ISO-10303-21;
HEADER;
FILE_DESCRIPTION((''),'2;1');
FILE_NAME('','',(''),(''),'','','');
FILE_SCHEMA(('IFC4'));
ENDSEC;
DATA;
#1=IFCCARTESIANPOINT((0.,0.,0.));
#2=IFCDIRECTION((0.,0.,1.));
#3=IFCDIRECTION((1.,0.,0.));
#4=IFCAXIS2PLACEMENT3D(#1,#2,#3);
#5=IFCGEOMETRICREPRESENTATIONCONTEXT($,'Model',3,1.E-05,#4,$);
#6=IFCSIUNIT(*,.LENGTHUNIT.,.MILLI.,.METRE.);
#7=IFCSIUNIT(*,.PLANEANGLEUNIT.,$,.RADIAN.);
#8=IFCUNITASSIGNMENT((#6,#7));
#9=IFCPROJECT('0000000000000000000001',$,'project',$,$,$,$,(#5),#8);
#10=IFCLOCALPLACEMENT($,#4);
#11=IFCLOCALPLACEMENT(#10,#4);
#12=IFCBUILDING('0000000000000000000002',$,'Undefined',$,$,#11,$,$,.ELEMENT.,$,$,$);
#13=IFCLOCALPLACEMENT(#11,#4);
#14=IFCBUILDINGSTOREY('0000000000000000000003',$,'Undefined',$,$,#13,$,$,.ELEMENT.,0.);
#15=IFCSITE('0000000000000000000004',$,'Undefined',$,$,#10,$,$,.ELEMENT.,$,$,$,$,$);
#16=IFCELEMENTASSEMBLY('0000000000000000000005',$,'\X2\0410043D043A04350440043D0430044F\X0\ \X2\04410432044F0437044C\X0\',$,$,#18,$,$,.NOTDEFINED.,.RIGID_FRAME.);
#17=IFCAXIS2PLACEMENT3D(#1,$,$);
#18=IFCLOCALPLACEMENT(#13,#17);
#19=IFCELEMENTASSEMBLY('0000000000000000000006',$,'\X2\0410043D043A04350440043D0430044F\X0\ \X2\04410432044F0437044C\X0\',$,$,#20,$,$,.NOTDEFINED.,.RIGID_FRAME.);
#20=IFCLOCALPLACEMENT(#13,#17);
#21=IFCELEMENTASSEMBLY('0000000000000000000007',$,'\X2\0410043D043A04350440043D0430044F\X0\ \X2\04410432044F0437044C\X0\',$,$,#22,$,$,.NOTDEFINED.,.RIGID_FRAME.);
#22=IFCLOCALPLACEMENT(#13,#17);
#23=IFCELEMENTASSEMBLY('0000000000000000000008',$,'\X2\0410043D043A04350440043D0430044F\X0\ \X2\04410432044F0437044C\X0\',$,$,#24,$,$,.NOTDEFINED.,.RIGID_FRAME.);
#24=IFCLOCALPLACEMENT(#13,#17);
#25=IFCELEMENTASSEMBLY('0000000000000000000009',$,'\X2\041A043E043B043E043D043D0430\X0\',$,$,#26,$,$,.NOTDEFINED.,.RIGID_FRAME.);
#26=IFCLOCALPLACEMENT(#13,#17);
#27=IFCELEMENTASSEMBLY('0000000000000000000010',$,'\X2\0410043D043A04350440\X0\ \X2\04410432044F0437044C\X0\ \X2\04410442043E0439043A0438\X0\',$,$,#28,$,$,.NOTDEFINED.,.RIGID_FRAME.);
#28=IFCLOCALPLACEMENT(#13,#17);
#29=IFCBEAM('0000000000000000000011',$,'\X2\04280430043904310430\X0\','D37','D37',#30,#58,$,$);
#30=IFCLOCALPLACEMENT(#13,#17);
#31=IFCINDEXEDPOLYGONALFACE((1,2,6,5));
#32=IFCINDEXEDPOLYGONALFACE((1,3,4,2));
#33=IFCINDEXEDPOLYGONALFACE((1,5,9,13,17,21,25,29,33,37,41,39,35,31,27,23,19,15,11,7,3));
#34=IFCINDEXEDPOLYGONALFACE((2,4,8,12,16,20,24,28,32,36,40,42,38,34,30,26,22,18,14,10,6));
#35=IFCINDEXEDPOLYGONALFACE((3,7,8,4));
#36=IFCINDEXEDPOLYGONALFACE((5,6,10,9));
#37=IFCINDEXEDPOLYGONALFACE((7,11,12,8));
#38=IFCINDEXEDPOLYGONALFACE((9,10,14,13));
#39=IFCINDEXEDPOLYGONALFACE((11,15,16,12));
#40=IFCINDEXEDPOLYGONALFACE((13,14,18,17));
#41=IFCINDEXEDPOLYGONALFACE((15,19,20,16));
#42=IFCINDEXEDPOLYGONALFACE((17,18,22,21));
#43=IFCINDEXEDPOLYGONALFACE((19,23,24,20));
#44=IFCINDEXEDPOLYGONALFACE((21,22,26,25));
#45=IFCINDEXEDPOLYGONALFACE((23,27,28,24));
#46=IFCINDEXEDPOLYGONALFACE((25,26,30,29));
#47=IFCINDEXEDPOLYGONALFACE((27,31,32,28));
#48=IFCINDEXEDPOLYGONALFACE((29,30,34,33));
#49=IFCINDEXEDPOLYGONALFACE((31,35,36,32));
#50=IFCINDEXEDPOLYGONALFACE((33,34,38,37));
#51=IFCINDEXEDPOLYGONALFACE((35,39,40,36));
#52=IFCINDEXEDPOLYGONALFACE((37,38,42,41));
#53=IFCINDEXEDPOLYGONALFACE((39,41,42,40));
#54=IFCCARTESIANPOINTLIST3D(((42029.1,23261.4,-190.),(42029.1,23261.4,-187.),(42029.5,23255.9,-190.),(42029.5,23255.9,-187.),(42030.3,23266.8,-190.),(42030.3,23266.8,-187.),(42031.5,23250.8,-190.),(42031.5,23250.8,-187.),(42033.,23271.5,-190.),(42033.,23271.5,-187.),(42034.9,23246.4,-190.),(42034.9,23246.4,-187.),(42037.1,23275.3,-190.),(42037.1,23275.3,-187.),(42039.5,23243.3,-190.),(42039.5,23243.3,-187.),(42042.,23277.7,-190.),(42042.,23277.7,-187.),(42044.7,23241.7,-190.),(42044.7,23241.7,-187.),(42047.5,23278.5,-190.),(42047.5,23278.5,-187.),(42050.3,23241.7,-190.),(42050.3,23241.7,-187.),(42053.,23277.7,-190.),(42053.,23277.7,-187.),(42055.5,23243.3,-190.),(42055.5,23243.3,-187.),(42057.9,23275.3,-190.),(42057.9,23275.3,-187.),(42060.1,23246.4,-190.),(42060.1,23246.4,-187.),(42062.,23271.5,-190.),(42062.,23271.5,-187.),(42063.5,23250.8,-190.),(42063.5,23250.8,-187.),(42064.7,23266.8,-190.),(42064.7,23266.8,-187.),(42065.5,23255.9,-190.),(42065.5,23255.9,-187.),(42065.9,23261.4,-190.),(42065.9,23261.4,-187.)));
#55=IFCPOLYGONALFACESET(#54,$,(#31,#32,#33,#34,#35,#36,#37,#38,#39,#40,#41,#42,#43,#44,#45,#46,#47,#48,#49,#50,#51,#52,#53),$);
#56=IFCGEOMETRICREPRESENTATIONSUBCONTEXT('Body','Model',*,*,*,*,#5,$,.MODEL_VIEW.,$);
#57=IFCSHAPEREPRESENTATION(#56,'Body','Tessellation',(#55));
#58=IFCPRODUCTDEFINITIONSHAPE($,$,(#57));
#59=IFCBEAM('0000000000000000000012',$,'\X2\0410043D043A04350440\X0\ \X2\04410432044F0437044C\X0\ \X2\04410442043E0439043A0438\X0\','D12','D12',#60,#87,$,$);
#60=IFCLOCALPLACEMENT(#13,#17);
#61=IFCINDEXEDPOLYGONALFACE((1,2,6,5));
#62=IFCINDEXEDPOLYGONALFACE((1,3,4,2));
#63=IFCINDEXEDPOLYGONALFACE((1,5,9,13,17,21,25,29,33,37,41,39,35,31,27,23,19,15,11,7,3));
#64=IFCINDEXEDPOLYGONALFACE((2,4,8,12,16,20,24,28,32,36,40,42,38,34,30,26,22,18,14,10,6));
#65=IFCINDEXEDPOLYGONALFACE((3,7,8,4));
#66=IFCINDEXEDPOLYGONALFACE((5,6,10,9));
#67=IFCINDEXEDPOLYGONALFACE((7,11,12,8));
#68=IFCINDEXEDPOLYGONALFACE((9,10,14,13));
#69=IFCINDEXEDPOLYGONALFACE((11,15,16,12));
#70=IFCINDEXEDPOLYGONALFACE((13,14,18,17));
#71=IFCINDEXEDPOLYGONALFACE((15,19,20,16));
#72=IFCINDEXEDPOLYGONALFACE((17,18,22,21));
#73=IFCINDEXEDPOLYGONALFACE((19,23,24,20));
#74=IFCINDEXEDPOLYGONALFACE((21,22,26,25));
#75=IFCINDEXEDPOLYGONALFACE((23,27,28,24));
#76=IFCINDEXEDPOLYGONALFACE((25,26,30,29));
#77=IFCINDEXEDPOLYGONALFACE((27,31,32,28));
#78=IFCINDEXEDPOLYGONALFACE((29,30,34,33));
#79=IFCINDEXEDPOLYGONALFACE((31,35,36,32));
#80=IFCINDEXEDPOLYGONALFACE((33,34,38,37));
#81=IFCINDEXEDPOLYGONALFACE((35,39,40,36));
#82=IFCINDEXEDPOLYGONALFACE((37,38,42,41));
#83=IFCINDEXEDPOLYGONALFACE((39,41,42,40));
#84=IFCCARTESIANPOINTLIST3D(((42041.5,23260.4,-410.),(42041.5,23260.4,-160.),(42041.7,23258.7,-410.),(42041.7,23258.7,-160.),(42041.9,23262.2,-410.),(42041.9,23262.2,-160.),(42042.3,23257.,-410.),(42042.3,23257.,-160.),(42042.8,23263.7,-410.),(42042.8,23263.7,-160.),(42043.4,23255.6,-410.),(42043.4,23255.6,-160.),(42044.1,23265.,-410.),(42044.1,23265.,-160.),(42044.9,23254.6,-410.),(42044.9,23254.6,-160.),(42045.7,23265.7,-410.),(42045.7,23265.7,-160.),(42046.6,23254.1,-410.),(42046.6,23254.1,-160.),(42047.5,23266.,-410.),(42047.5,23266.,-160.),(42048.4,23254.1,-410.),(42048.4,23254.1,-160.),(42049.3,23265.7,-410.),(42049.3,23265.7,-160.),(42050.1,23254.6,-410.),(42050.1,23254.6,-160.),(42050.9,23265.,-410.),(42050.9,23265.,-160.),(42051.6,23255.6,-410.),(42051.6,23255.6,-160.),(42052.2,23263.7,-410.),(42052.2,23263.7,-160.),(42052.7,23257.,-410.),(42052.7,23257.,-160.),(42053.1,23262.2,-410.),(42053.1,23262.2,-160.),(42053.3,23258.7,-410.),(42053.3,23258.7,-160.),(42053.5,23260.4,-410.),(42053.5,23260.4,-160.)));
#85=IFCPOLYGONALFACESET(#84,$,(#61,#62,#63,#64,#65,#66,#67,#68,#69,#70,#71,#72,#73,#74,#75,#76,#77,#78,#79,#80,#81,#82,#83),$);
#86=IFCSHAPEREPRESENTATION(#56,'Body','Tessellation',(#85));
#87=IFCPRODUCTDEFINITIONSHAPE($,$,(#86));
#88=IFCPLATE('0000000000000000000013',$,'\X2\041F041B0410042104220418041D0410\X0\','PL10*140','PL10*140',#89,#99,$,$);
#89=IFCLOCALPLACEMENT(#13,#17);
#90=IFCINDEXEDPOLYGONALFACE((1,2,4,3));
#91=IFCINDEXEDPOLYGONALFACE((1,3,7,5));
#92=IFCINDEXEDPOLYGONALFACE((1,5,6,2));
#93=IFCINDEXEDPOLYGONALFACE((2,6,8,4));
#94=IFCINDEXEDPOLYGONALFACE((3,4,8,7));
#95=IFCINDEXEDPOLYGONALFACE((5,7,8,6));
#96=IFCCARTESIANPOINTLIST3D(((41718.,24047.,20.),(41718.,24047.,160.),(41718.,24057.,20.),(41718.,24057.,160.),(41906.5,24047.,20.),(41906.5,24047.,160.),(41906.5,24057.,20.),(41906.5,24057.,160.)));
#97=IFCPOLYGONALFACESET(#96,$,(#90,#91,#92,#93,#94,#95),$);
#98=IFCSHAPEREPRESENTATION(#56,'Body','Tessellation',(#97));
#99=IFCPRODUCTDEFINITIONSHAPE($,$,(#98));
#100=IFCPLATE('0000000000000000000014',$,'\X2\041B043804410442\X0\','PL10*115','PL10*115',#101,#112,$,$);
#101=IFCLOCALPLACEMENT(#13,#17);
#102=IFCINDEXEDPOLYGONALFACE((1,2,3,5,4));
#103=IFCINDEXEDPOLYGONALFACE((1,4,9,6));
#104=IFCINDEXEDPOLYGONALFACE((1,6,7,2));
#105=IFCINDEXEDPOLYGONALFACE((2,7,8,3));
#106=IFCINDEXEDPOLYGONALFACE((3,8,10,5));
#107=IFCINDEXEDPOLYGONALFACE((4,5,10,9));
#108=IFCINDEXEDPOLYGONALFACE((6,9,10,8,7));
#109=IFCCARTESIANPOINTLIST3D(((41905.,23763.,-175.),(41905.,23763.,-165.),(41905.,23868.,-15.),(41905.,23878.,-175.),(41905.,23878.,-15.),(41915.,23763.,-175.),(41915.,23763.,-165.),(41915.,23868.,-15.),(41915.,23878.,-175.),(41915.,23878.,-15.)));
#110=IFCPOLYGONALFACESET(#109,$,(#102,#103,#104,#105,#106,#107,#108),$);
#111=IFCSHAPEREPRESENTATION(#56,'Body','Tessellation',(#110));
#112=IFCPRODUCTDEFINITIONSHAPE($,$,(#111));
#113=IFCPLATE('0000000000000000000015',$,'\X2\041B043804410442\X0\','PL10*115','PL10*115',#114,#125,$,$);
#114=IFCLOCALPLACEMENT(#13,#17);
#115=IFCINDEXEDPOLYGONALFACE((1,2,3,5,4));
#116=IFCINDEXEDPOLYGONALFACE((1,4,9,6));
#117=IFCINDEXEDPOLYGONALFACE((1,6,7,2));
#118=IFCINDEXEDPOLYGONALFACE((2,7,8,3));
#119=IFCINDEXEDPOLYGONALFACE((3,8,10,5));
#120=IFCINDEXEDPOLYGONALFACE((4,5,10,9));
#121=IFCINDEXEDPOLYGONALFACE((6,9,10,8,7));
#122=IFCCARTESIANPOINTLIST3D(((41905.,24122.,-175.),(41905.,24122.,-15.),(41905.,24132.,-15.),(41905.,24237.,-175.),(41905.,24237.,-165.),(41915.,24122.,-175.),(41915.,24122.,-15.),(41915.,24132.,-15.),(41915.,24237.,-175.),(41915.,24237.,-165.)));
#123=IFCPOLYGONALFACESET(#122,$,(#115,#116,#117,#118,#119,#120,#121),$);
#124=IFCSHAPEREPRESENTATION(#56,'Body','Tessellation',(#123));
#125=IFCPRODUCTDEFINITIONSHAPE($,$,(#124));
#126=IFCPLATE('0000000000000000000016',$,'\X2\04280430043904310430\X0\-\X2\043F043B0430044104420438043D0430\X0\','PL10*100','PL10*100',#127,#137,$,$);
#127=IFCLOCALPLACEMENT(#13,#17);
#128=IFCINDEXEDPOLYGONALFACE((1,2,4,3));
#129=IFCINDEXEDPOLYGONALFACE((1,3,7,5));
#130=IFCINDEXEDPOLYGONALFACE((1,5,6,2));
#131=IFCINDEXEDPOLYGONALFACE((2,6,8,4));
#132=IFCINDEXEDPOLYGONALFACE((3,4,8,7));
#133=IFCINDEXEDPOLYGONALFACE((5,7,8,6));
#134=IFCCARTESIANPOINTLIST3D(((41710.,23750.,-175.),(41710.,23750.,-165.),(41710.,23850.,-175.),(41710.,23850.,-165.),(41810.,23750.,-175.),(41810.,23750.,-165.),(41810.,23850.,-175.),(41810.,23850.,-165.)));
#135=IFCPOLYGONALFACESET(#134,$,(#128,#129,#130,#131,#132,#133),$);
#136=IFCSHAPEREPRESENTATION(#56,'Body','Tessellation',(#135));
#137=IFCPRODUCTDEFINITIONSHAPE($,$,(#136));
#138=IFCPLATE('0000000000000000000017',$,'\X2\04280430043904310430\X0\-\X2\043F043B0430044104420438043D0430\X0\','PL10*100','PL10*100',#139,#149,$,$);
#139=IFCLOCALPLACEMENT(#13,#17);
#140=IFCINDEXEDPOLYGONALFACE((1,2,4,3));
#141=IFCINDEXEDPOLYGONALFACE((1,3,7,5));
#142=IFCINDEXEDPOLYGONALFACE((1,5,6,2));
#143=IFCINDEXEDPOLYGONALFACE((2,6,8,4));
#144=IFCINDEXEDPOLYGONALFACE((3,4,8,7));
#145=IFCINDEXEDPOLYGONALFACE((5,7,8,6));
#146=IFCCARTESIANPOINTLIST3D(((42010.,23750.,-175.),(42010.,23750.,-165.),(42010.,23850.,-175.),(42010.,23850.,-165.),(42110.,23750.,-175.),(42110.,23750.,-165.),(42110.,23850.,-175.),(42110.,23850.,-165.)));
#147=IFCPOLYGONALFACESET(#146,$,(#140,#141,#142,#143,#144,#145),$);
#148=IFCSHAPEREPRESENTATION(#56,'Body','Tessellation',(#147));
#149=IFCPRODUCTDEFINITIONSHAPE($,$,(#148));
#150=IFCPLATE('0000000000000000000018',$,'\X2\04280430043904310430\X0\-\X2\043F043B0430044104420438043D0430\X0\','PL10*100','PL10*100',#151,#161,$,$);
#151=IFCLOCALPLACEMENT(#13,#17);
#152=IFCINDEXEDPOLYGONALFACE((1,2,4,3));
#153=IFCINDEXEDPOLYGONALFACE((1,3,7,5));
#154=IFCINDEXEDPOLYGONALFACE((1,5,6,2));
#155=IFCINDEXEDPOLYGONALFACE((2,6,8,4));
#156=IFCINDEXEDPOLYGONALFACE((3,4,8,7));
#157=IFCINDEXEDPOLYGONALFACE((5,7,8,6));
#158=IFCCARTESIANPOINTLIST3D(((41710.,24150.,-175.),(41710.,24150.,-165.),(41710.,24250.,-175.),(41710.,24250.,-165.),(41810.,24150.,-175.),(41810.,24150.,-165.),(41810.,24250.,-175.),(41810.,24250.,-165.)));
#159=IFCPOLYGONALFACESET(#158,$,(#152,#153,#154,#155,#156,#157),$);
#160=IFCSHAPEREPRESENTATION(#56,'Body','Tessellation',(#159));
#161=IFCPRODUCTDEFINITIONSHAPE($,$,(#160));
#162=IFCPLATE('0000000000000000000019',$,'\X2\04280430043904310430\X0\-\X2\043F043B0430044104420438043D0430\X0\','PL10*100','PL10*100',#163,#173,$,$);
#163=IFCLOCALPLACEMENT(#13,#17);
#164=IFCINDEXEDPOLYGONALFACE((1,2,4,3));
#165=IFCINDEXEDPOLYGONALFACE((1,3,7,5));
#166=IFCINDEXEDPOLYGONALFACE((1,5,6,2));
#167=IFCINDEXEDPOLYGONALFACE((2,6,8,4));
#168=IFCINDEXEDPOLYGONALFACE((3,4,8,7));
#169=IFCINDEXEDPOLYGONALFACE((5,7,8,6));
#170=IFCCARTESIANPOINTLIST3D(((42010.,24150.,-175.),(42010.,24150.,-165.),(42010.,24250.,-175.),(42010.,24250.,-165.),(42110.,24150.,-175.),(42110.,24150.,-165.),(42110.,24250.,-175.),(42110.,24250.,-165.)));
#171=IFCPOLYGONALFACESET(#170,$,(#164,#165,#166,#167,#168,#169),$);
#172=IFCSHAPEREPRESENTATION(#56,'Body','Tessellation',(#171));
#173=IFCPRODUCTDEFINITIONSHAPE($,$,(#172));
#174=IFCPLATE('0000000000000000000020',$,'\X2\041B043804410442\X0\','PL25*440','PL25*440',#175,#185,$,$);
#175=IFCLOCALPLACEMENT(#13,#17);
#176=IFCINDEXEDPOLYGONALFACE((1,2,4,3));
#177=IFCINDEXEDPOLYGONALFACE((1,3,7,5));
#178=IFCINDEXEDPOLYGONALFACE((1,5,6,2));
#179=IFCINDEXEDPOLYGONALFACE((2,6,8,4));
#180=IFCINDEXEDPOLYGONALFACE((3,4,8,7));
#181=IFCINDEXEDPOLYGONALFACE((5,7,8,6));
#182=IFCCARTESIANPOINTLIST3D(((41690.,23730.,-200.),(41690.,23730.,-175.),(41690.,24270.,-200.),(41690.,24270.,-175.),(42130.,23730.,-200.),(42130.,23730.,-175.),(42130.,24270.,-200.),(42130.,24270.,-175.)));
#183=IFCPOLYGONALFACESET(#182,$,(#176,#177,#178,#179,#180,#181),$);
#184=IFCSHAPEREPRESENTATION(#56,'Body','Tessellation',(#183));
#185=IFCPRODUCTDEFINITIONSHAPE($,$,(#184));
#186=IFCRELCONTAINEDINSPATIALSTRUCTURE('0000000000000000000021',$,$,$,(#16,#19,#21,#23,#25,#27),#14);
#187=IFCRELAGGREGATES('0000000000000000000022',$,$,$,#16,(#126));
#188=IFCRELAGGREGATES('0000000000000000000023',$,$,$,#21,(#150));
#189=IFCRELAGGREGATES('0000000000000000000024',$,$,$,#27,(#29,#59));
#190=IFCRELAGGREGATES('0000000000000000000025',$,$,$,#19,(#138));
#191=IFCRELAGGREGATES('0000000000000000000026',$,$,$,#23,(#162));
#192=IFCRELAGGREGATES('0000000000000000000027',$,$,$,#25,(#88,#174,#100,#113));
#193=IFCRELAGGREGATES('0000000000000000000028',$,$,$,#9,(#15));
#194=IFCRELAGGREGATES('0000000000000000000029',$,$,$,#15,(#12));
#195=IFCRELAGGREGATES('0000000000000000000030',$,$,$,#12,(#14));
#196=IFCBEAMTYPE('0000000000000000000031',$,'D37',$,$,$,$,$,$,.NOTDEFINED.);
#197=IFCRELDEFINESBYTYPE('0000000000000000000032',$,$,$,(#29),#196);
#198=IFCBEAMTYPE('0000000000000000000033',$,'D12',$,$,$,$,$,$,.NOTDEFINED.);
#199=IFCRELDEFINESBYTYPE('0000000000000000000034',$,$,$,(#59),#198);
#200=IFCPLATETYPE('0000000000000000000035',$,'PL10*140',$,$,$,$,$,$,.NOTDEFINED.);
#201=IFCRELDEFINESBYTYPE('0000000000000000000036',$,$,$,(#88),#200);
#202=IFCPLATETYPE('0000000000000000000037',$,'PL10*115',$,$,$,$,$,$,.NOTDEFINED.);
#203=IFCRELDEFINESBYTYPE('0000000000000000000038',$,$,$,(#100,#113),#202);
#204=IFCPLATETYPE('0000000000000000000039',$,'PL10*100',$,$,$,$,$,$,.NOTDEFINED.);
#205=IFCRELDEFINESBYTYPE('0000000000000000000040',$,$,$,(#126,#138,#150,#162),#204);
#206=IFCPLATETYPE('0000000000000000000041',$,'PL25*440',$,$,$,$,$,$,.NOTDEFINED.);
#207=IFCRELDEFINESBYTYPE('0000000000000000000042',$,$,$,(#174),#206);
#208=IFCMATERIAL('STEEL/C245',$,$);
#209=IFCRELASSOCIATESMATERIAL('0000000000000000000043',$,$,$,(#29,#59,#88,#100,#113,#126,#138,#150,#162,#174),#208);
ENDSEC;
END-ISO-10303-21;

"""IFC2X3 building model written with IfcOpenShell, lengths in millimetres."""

from ifc_helpers import new_model, si_unit, frame, origin_with_axes, origin_2d_with_axis, place, context, subcontext, project, spatial, polyline, circle, outline, extrude, material, type_object, element, aggregate, save


model = new_model("IFC2X3")

# Units and contexts
model_context = context("Model", 3, precision=1e-05, world=origin_with_axes())
body_context = subcontext(model_context, "Body", "Model", "MODEL_VIEW")
ifc_project = project(units=[si_unit("LENGTHUNIT", "METRE", prefix="MILLI"), si_unit("PLANEANGLEUNIT", "RADIAN")], contexts=[model_context])

# Site, building, storey
site_placement = place(None, origin_with_axes())
site = spatial("IfcSite", under=ifc_project, at=site_placement, Name="Undefined", CompositionType="ELEMENT")
building_placement = place(site_placement, origin_with_axes())
building = spatial("IfcBuilding", under=site, at=building_placement, Name="Undefined", CompositionType="ELEMENT")
storey_placement = place(building_placement, origin_with_axes())
storey = spatial("IfcBuildingStorey", under=building, at=storey_placement, Name="Undefined", CompositionType="ELEMENT", Elevation=0.0)

# Element assembly
ifc_material_1 = material(Name="STEEL/C245")
assembly_1_placement = place(storey_placement, origin_with_axes())
assembly_1 = element("IfcElementAssembly", 1, at=assembly_1_placement, inside=storey, Name="Анкерная связь", AssemblyPlace="NOTDEFINED", PredefinedType="RIGID_FRAME")

# Element assembly
assembly_2_placement = place(storey_placement, origin_with_axes())
assembly_2 = element("IfcElementAssembly", 2, at=assembly_2_placement, inside=storey, Name="Анкерная связь", AssemblyPlace="NOTDEFINED", PredefinedType="RIGID_FRAME")

# Element assembly
assembly_3_placement = place(storey_placement, origin_with_axes())
assembly_3 = element("IfcElementAssembly", 3, at=assembly_3_placement, inside=storey, Name="Анкерная связь", AssemblyPlace="NOTDEFINED", PredefinedType="RIGID_FRAME")

# Element assembly
assembly_4_placement = place(storey_placement, origin_with_axes())
assembly_4 = element("IfcElementAssembly", 4, at=assembly_4_placement, inside=storey, Name="Анкерная связь", AssemblyPlace="NOTDEFINED", PredefinedType="RIGID_FRAME")

# Element assembly
assembly_5_placement = place(storey_placement, origin_with_axes())
assembly_5 = element("IfcElementAssembly", 5, at=assembly_5_placement, inside=storey, Name="Колонна", AssemblyPlace="NOTDEFINED", PredefinedType="RIGID_FRAME")

# Element assembly, beams
assembly_6_placement = place(storey_placement, origin_with_axes())
assembly_6 = element("IfcElementAssembly", 6, at=assembly_6_placement, inside=storey, Name="Анкер связь стойки", AssemblyPlace="NOTDEFINED", PredefinedType="RIGID_FRAME")
beam_type_1 = type_object("IfcBeamType", Name="D37", PredefinedType="NOTDEFINED")
beam_1_placement = place(assembly_6_placement, frame((42047.5, 23260.0, -187.0), z_axis=(-1.0, 0.0, 0.0), x_axis=(0.0, 0.0, -1.0)))
beam_1 = element("IfcBeam", 7, at=beam_1_placement, type_object=beam_type_1, material=ifc_material_1, Name="Шайба", Description="D37", ObjectType="D37", context=body_context, shape_type="SweptSolid", body=[
    extrude(circle(Radius=18.5, at=origin_2d_with_axis()), frame((3.0, 0.0, 0.0), z_axis=(-1.0, 0.0, 0.0), x_axis=(0.0, -1.0, 0.0)), (0.0, 0.0, 1.0), 3.0),
])
beam_type_2 = type_object("IfcBeamType", Name="D12", PredefinedType="NOTDEFINED")
beam_2_placement = place(assembly_6_placement, frame((42047.5, 23260.0, -160.0), z_axis=(-1.0, 0.0, 0.0), x_axis=(0.0, 0.0, -1.0)))
beam_2 = element("IfcBeam", 8, at=beam_2_placement, type_object=beam_type_2, material=ifc_material_1, Name="Анкер связь стойки", Description="D12", ObjectType="D12", context=body_context, shape_type="SweptSolid", body=[
    extrude(circle(Radius=6.0, at=origin_2d_with_axis()), frame((250.0, 0.0, 0.0), z_axis=(-1.0, 0.0, 0.0), x_axis=(0.0, -1.0, 0.0)), (0.0, 0.0, 1.0), 250.0),
])

# Plates
plate_type_1 = type_object("IfcPlateType", Name="PL10*140", PredefinedType="NOTDEFINED")
plate_1_placement = place(assembly_5_placement, frame((41906.5, 24052.0, 20.0), z_axis=(0.0, 1.0, 0.0), x_axis=(-1.0, 0.0, 0.0)))
plate_1 = element("IfcPlate", 9, at=plate_1_placement, type_object=plate_type_1, material=ifc_material_1, Name="ПЛАСТИНА", Description="PL10*140", ObjectType="PL10*140", context=body_context, shape_type="SweptSolid", body=[
    extrude(outline(polyline([(0.0, 0.0), (188.5, 0.0), (188.5, 140.0), (0.0, 140.0), (0.0, 0.0)])), frame((0.0, 0.0, -5.0), z_axis=(0.0, 0.0, 1.0), x_axis=(1.0, 0.0, 0.0)), (0.0, 0.0, 1.0), 10.0),
])
plate_type_2 = type_object("IfcPlateType", Name="PL10*115", PredefinedType="NOTDEFINED")
plate_2_placement = place(assembly_5_placement, frame((41910.0, 23878.0, -15.0), z_axis=(-1.0, 0.0, 0.0), x_axis=(0.0, 0.0, -1.0)))
plate_2 = element("IfcPlate", 10, at=plate_2_placement, type_object=plate_type_2, material=ifc_material_1, Name="Лист", Description="PL10*115", ObjectType="PL10*115", context=body_context, shape_type="SweptSolid", body=[
    extrude(outline(polyline([(0.0, 0.0), (160.0, 0.0), (160.0, 115.0), (150.0, 115.0), (0.0, 10.0), (0.0, 0.0)])), frame((0.0, 0.0, -5.0), z_axis=(0.0, 0.0, 1.0), x_axis=(1.0, 0.0, 0.0)), (0.0, 0.0, 1.0), 10.0),
])
plate_3_placement = place(assembly_5_placement, frame((41910.0, 24122.0, -15.0), z_axis=(1.0, 0.0, 0.0), x_axis=(0.0, 0.0, -1.0)))
plate_3 = element("IfcPlate", 11, at=plate_3_placement, type_object=plate_type_2, material=ifc_material_1, Name="Лист", Description="PL10*115", ObjectType="PL10*115", context=body_context, shape_type="SweptSolid", body=[
    extrude(outline(polyline([(0.0, 0.0), (160.0, 0.0), (160.0, 115.0), (150.0, 115.0), (0.0, 10.0), (0.0, 0.0)])), frame((0.0, 0.0, -5.0), z_axis=(0.0, 0.0, 1.0), x_axis=(1.0, 0.0, 0.0)), (0.0, 0.0, 1.0), 10.0),
])
plate_type_3 = type_object("IfcPlateType", Name="PL10*100", PredefinedType="NOTDEFINED")
plate_4_placement = place(assembly_1_placement, frame((41810.0, 23850.0, -170.0), z_axis=(0.0, 0.0, -1.0), x_axis=(0.0, -1.0, 0.0)))
plate_4 = element("IfcPlate", 12, at=plate_4_placement, type_object=plate_type_3, material=ifc_material_1, Name="Шайба-пластина", Description="PL10*100", ObjectType="PL10*100", context=body_context, shape_type="SweptSolid", body=[
    extrude(outline(polyline([(0.0, 0.0), (100.0, 0.0), (100.0, 100.0), (0.0, 100.0), (0.0, 0.0)])), frame((0.0, 0.0, -5.0), z_axis=(0.0, 0.0, 1.0), x_axis=(1.0, 0.0, 0.0)), (0.0, 0.0, 1.0), 10.0),
])
aggregate(assembly_1, [plate_4])
plate_5_placement = place(assembly_2_placement, frame((42110.0, 23850.0, -170.0), z_axis=(0.0, 0.0, -1.0), x_axis=(0.0, -1.0, 0.0)))
plate_5 = element("IfcPlate", 13, at=plate_5_placement, type_object=plate_type_3, material=ifc_material_1, Name="Шайба-пластина", Description="PL10*100", ObjectType="PL10*100", context=body_context, shape_type="SweptSolid", body=[
    extrude(outline(polyline([(0.0, 0.0), (100.0, 0.0), (100.0, 100.0), (0.0, 100.0), (0.0, 0.0)])), frame((0.0, 0.0, -5.0), z_axis=(0.0, 0.0, 1.0), x_axis=(1.0, 0.0, 0.0)), (0.0, 0.0, 1.0), 10.0),
])
plate_6_placement = place(assembly_3_placement, frame((41810.0, 24250.0, -170.0), z_axis=(0.0, 0.0, -1.0), x_axis=(0.0, -1.0, 0.0)))
plate_6 = element("IfcPlate", 14, at=plate_6_placement, type_object=plate_type_3, material=ifc_material_1, Name="Шайба-пластина", Description="PL10*100", ObjectType="PL10*100", context=body_context, shape_type="SweptSolid", body=[
    extrude(outline(polyline([(0.0, 0.0), (100.0, 0.0), (100.0, 100.0), (0.0, 100.0), (0.0, 0.0)])), frame((0.0, 0.0, -5.0), z_axis=(0.0, 0.0, 1.0), x_axis=(1.0, 0.0, 0.0)), (0.0, 0.0, 1.0), 10.0),
])
aggregate(assembly_3, [plate_6])
plate_7_placement = place(assembly_4_placement, frame((42110.0, 24250.0, -170.0), z_axis=(0.0, 0.0, -1.0), x_axis=(0.0, -1.0, 0.0)))
plate_7 = element("IfcPlate", 15, at=plate_7_placement, type_object=plate_type_3, material=ifc_material_1, Name="Шайба-пластина", Description="PL10*100", ObjectType="PL10*100", context=body_context, shape_type="SweptSolid", body=[
    extrude(outline(polyline([(0.0, 0.0), (100.0, 0.0), (100.0, 100.0), (0.0, 100.0), (0.0, 0.0)])), frame((0.0, 0.0, -5.0), z_axis=(0.0, 0.0, 1.0), x_axis=(1.0, 0.0, 0.0)), (0.0, 0.0, 1.0), 10.0),
])
plate_type_4 = type_object("IfcPlateType", Name="PL25*440", PredefinedType="NOTDEFINED")
plate_8_placement = place(assembly_5_placement, frame((41910.0, 23730.0, -187.5), z_axis=(0.0, 0.0, 1.0), x_axis=(0.0, 1.0, 0.0)))
plate_8 = element("IfcPlate", 16, at=plate_8_placement, type_object=plate_type_4, material=ifc_material_1, Name="Лист", Description="PL25*440", ObjectType="PL25*440", context=body_context, shape_type="SweptSolid", body=[
    extrude(outline(polyline([(0.0, 220.0), (540.0, 220.0), (540.0, -220.0), (0.0, -220.0), (0.0, 220.0)])), frame((0.0, 0.0, -12.5), z_axis=(0.0, 0.0, 1.0), x_axis=(1.0, 0.0, 0.0)), (0.0, 0.0, 1.0), 25.0),
])

aggregate(assembly_6, [beam_1, beam_2])

aggregate(assembly_2, [plate_5])
aggregate(assembly_4, [plate_7])
aggregate(assembly_5, [plate_1, plate_8, plate_2, plate_3])

save(model, "model.ifc")
